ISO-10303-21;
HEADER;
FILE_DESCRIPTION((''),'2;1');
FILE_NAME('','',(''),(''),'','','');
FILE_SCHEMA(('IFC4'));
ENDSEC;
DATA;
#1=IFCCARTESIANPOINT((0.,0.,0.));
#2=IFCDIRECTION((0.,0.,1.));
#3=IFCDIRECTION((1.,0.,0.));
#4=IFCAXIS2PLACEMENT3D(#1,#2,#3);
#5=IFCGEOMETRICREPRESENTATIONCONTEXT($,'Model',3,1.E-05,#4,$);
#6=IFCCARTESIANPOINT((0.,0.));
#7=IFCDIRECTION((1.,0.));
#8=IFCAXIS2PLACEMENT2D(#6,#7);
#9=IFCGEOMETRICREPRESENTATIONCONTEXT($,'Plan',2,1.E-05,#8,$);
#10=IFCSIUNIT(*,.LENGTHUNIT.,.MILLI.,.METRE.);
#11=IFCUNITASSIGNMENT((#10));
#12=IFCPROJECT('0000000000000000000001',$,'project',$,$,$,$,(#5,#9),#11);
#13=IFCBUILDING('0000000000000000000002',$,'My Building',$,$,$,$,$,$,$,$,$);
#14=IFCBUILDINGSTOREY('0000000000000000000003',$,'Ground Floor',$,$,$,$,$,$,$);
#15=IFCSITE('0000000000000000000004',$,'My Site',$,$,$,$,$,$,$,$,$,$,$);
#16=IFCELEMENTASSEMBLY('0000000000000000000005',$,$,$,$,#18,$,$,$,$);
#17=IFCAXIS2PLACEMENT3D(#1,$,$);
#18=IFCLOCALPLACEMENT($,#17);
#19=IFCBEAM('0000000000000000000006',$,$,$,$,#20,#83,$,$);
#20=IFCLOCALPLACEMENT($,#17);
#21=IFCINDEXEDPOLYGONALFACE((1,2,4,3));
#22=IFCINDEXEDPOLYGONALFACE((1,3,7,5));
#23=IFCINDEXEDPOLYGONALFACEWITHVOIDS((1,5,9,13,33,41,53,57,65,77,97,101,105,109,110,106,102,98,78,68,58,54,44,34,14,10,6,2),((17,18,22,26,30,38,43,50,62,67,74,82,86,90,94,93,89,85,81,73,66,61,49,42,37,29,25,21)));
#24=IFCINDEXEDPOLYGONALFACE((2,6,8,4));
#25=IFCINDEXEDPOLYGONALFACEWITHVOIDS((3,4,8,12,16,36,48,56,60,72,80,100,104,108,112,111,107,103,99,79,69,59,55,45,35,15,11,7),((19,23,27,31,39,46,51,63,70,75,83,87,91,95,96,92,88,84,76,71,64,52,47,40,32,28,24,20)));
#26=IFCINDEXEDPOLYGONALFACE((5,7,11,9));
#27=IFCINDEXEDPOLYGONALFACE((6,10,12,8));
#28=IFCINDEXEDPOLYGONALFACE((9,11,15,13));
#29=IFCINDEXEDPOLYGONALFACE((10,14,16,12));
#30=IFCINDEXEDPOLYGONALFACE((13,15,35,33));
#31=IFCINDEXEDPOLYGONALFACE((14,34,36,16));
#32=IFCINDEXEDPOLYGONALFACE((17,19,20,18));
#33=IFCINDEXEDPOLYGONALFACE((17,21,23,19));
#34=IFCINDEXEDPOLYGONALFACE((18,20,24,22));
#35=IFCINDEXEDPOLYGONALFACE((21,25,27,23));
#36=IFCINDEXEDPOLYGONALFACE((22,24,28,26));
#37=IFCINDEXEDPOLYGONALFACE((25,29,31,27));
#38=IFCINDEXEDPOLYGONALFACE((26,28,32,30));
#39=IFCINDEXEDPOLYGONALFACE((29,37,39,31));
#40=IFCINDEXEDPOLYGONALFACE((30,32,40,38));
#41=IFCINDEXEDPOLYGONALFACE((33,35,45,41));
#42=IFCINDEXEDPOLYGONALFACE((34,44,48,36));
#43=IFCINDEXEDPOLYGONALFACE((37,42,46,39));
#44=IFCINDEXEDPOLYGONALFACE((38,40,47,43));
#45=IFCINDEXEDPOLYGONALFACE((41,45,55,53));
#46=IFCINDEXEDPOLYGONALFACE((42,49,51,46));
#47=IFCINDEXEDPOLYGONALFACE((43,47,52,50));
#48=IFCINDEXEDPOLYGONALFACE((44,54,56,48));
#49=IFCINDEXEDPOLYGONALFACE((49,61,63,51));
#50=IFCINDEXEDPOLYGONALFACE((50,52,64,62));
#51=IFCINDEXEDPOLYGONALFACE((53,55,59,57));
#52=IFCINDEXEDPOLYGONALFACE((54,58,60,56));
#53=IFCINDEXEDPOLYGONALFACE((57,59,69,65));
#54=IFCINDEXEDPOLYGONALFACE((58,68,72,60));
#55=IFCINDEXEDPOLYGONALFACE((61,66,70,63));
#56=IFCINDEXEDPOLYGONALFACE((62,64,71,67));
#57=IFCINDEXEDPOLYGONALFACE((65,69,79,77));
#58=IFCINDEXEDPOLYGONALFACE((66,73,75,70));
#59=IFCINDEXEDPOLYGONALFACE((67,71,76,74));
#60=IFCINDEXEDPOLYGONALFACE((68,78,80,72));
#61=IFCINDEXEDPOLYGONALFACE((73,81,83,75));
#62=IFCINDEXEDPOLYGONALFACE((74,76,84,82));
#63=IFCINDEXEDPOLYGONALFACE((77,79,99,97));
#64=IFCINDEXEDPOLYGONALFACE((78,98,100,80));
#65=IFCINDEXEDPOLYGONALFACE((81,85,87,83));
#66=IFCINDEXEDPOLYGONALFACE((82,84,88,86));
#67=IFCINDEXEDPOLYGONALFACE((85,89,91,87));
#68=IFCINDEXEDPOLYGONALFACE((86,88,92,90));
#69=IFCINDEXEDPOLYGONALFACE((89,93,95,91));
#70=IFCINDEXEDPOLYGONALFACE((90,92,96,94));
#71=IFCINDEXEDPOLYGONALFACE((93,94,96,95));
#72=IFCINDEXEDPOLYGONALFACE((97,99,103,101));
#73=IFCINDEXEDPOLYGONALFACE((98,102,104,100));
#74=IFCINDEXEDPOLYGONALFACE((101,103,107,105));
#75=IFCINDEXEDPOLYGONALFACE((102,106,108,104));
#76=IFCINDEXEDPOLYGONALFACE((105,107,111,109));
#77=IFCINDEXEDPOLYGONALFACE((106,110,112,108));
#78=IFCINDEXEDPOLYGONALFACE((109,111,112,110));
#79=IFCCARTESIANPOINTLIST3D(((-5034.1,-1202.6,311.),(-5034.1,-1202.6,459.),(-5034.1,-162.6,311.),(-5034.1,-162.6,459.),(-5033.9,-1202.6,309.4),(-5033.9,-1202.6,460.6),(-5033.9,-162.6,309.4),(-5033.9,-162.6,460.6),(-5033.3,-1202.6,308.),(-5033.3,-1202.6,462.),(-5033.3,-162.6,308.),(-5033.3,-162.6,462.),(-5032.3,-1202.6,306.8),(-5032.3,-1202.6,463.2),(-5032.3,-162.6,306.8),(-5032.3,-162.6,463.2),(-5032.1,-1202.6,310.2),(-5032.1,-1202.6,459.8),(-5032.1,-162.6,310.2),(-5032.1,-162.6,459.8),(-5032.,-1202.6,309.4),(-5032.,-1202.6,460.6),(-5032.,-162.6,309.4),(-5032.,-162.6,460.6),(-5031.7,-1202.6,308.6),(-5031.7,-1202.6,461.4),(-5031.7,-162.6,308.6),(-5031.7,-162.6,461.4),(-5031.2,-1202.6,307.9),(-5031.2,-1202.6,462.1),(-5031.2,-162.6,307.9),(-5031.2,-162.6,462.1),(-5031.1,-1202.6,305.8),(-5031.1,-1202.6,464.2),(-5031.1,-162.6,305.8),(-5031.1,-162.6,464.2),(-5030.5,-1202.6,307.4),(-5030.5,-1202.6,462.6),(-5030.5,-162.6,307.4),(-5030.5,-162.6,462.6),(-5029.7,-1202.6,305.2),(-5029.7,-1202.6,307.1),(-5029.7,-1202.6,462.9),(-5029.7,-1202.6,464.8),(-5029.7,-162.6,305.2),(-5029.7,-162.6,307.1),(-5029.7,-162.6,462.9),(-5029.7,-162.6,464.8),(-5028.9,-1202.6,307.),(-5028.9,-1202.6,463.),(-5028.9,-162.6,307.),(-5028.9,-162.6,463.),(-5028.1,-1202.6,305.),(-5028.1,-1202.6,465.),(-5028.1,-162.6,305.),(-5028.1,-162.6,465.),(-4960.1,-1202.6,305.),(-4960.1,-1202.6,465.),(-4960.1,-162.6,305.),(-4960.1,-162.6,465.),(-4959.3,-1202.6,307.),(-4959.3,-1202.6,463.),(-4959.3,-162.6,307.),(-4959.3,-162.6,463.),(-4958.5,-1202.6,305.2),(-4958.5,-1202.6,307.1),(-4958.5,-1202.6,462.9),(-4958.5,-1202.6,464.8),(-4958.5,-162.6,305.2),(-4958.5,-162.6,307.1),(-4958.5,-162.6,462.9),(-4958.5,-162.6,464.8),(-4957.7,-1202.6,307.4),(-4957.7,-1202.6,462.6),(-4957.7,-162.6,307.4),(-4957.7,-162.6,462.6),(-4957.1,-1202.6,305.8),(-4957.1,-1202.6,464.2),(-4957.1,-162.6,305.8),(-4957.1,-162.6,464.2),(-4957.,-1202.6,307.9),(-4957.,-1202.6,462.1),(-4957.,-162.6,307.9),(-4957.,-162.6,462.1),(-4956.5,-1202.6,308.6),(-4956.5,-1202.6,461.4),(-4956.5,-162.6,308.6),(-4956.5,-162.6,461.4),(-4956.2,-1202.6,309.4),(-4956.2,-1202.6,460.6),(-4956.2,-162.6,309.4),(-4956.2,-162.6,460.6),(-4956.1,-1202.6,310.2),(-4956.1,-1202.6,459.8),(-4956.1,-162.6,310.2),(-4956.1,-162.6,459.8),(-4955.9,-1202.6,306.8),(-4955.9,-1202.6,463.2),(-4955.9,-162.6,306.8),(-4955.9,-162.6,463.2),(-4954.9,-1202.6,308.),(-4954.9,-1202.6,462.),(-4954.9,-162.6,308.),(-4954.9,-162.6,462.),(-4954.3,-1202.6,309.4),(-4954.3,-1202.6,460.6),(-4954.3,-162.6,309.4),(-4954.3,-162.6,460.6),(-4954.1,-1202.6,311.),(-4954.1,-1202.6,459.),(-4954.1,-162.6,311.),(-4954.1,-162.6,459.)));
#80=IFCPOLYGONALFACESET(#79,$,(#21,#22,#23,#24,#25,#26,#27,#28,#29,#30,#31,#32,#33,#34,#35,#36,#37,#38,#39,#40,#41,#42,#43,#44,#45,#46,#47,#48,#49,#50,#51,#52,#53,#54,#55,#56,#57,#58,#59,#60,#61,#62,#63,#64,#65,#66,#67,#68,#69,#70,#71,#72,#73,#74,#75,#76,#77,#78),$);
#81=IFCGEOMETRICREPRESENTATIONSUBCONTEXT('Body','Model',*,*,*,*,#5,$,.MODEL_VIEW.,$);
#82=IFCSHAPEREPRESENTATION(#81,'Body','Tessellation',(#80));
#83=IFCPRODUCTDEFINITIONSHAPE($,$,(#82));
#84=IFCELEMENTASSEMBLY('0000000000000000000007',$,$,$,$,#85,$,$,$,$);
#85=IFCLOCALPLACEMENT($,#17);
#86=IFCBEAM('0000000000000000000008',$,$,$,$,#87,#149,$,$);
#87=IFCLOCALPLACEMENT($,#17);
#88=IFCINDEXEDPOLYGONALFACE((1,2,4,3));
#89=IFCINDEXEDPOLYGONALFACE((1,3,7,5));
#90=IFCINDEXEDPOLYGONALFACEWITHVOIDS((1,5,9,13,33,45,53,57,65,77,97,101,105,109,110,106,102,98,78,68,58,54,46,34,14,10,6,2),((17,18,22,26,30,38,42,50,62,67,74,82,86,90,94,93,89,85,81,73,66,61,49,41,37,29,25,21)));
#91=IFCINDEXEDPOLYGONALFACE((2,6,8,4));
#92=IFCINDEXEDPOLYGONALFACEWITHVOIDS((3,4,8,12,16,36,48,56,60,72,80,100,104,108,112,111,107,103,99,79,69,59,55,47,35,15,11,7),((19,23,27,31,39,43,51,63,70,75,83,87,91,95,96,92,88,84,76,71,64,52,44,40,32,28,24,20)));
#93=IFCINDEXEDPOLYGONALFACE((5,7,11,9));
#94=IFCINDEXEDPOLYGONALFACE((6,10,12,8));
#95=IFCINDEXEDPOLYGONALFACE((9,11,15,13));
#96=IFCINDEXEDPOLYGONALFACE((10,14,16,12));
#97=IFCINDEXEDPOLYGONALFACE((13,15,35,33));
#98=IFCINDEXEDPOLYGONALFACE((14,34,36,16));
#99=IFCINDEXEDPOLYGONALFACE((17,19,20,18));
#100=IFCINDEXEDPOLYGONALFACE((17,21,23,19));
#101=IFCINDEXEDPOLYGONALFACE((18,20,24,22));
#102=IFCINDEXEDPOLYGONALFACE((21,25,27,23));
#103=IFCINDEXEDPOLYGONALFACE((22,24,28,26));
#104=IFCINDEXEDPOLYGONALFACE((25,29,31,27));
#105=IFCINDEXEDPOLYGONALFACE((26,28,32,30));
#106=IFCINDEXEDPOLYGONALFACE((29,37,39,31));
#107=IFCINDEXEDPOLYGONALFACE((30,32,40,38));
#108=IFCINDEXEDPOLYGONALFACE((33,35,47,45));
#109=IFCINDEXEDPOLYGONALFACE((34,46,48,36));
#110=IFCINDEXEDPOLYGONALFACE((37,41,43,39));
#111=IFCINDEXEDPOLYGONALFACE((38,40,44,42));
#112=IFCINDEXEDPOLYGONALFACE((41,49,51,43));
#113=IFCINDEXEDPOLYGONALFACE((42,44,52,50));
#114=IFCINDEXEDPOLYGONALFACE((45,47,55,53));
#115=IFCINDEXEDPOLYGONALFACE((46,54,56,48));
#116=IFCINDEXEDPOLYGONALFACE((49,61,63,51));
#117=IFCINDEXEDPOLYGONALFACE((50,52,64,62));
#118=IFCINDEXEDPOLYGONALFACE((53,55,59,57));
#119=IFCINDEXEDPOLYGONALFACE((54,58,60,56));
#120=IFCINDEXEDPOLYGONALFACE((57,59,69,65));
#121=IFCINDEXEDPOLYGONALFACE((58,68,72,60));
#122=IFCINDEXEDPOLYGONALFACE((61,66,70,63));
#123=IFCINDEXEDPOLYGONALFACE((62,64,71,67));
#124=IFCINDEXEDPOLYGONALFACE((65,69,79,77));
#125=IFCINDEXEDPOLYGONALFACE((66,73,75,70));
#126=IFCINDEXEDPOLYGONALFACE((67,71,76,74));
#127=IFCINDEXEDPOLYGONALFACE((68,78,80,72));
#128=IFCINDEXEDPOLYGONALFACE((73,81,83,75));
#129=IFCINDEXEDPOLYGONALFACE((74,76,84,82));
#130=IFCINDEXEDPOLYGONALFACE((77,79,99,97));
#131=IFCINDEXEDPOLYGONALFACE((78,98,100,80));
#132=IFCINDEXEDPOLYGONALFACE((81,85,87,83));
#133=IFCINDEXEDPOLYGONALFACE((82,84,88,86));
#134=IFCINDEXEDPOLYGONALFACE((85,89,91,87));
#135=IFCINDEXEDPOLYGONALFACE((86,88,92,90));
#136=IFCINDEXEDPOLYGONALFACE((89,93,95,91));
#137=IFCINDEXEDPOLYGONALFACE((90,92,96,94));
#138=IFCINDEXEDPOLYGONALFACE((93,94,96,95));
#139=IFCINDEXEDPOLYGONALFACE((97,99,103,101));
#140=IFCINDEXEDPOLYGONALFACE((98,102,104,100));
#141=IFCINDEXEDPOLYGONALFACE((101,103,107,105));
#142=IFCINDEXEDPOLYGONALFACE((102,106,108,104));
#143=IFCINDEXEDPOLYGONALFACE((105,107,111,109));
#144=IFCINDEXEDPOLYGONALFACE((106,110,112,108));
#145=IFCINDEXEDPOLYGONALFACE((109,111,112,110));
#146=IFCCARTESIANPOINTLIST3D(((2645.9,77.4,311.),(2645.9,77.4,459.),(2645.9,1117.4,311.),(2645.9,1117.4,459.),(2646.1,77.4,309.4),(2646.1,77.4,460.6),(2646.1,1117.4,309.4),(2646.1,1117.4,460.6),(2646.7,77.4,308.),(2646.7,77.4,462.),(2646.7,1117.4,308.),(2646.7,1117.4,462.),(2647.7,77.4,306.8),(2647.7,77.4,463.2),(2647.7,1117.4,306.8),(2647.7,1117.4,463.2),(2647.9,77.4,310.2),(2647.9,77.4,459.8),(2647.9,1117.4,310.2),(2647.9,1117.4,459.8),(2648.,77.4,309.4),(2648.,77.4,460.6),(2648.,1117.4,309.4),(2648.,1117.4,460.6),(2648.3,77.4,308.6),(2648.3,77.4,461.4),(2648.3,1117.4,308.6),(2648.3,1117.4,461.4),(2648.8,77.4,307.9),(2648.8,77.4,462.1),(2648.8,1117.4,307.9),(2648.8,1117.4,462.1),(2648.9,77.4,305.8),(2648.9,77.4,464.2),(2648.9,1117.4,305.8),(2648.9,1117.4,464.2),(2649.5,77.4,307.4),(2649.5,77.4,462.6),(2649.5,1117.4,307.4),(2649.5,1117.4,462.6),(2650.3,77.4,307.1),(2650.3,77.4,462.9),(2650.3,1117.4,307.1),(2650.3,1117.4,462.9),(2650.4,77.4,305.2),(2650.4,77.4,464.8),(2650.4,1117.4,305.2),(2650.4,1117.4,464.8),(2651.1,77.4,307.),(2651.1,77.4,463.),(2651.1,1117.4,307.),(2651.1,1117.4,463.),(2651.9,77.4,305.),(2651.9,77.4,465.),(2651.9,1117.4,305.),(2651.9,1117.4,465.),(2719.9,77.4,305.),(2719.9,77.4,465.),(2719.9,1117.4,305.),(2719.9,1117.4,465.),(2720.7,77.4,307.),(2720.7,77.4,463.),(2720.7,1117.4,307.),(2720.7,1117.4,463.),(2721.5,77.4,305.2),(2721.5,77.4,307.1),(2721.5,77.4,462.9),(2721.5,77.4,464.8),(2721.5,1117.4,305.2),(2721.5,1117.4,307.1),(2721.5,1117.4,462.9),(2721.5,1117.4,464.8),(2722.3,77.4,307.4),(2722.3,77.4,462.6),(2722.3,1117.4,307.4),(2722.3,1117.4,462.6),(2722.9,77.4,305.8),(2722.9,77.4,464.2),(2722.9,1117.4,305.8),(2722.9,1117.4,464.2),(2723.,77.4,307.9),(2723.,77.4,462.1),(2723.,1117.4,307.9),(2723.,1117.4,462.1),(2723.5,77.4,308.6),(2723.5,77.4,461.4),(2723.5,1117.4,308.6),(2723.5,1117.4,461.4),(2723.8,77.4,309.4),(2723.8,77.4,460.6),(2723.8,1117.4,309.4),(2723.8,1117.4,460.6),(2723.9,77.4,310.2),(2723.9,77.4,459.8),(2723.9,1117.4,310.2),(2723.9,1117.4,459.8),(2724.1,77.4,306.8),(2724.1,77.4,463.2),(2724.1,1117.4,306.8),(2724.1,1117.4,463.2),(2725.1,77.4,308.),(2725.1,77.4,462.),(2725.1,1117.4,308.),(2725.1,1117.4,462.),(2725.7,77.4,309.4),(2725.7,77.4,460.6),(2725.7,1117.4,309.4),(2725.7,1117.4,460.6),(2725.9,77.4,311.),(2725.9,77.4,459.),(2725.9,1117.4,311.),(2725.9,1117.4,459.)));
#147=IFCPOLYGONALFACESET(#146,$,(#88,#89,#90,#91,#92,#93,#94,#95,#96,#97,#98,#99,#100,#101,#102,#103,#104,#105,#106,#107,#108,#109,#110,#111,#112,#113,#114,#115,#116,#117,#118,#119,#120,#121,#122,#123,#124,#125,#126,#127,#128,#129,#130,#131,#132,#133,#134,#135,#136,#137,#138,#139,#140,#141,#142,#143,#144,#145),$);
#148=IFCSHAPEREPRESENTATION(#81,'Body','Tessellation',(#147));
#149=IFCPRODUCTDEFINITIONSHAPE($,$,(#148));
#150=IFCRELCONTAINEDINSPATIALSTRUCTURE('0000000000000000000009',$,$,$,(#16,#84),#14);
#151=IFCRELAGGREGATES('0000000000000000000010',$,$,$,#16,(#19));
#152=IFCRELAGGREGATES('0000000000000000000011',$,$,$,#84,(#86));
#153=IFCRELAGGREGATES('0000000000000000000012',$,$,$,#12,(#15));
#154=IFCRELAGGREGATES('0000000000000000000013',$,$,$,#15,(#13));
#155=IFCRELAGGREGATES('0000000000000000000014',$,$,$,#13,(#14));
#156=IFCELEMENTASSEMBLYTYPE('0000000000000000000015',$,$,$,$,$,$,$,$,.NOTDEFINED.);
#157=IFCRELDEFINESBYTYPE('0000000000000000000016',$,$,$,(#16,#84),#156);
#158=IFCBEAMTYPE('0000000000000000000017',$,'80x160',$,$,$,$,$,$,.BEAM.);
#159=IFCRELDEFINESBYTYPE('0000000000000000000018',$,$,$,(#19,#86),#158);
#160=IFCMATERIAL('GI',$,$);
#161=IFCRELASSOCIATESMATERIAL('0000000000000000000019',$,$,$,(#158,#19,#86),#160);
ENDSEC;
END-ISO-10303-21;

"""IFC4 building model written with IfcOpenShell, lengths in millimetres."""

from ifc_helpers import new_model, si_unit, frame, origin_with_axes, origin_2d_with_axis, place, context, subcontext, project, spatial, hollow_rectangle, extrude, material, material_profile, profile_set, profile_usage, type_object, element, aggregate, save


model = new_model("IFC4")

# Units and contexts
model_context = context("Model", 3, precision=1e-05, world=origin_with_axes())
plan_context = context("Plan", 2, precision=1e-05, world=origin_2d_with_axis())
body_context = subcontext(model_context, "Body", "Model", "MODEL_VIEW")
ifc_project = project(units=[si_unit("LENGTHUNIT", "METRE", prefix="MILLI")], contexts=[model_context, plan_context])

# Site, building, storey
site = spatial("IfcSite", under=ifc_project, Name="My Site")
building = spatial("IfcBuilding", under=site, Name="My Building")
storey = spatial("IfcBuildingStorey", under=building, Name="Ground Floor")

# Shared definitions
ifc_material_1 = material(Name="GI")

# Element assemblies, beams
element_assembly_type_1 = type_object("IfcElementAssemblyType", PredefinedType="NOTDEFINED")
ifc_material_profile_1 = material_profile(ifc_material_1, hollow_rectangle(XDim=80.0, YDim=160.0, WallThickness=2.0, InnerFilletRadius=3.2, OuterFilletRadius=6.0))
ifc_profile_set_1 = profile_set([ifc_material_profile_1], Name="80x160 GI Rectangular Hollow")
beam_type = type_object("IfcBeamType", Name="80x160", PredefinedType="BEAM", material=ifc_profile_set_1)
assembly_1_placement = place(None, frame((-4994.1, -1282.6, 385.0), z_axis=(0.0, 1.0, 0.0), x_axis=(1.0, 0.0, 0.0)))
assembly_1 = element("IfcElementAssembly", 1, at=assembly_1_placement, inside=storey, type_object=element_assembly_type_1)
ifc_profile_usage_1 = profile_usage(ifc_profile_set_1)
beam_1_placement = place(assembly_1_placement, frame((0.0, 0.0, 80.0), z_axis=(0.0, 0.0, 1.0), x_axis=(1.0, 0.0, 0.0)))
beam_1 = element("IfcBeam", 2, at=beam_1_placement, type_object=beam_type, material=ifc_profile_usage_1, context=body_context, shape_type="SweptSolid", body=[
    extrude(hollow_rectangle(XDim=80.0, YDim=160.0, WallThickness=2.0, InnerFilletRadius=3.2, OuterFilletRadius=6.0), origin_with_axes(), (0.0, 0.0, 1.0), 1040.0),
])
aggregate(assembly_1, [beam_1])
assembly_2_placement = place(None, frame((2685.9, -2.6, 385.0), z_axis=(0.0, 1.0, 0.0), x_axis=(1.0, 0.0, 0.0)))
assembly_2 = element("IfcElementAssembly", 3, at=assembly_2_placement, inside=storey, type_object=element_assembly_type_1)
ifc_profile_usage_2 = profile_usage(ifc_profile_set_1)
beam_2_placement = place(assembly_2_placement, frame((0.0, 0.0, 80.0), z_axis=(0.0, 0.0, 1.0), x_axis=(1.0, 0.0, 0.0)))
beam_2 = element("IfcBeam", 4, at=beam_2_placement, type_object=beam_type, material=ifc_profile_usage_2, context=body_context, shape_type="SweptSolid", body=[
    extrude(hollow_rectangle(XDim=80.0, YDim=160.0, WallThickness=2.0, InnerFilletRadius=3.2, OuterFilletRadius=6.0), origin_with_axes(), (0.0, 0.0, 1.0), 1040.0),
])
aggregate(assembly_2, [beam_2])

save(model, "model.ifc")
